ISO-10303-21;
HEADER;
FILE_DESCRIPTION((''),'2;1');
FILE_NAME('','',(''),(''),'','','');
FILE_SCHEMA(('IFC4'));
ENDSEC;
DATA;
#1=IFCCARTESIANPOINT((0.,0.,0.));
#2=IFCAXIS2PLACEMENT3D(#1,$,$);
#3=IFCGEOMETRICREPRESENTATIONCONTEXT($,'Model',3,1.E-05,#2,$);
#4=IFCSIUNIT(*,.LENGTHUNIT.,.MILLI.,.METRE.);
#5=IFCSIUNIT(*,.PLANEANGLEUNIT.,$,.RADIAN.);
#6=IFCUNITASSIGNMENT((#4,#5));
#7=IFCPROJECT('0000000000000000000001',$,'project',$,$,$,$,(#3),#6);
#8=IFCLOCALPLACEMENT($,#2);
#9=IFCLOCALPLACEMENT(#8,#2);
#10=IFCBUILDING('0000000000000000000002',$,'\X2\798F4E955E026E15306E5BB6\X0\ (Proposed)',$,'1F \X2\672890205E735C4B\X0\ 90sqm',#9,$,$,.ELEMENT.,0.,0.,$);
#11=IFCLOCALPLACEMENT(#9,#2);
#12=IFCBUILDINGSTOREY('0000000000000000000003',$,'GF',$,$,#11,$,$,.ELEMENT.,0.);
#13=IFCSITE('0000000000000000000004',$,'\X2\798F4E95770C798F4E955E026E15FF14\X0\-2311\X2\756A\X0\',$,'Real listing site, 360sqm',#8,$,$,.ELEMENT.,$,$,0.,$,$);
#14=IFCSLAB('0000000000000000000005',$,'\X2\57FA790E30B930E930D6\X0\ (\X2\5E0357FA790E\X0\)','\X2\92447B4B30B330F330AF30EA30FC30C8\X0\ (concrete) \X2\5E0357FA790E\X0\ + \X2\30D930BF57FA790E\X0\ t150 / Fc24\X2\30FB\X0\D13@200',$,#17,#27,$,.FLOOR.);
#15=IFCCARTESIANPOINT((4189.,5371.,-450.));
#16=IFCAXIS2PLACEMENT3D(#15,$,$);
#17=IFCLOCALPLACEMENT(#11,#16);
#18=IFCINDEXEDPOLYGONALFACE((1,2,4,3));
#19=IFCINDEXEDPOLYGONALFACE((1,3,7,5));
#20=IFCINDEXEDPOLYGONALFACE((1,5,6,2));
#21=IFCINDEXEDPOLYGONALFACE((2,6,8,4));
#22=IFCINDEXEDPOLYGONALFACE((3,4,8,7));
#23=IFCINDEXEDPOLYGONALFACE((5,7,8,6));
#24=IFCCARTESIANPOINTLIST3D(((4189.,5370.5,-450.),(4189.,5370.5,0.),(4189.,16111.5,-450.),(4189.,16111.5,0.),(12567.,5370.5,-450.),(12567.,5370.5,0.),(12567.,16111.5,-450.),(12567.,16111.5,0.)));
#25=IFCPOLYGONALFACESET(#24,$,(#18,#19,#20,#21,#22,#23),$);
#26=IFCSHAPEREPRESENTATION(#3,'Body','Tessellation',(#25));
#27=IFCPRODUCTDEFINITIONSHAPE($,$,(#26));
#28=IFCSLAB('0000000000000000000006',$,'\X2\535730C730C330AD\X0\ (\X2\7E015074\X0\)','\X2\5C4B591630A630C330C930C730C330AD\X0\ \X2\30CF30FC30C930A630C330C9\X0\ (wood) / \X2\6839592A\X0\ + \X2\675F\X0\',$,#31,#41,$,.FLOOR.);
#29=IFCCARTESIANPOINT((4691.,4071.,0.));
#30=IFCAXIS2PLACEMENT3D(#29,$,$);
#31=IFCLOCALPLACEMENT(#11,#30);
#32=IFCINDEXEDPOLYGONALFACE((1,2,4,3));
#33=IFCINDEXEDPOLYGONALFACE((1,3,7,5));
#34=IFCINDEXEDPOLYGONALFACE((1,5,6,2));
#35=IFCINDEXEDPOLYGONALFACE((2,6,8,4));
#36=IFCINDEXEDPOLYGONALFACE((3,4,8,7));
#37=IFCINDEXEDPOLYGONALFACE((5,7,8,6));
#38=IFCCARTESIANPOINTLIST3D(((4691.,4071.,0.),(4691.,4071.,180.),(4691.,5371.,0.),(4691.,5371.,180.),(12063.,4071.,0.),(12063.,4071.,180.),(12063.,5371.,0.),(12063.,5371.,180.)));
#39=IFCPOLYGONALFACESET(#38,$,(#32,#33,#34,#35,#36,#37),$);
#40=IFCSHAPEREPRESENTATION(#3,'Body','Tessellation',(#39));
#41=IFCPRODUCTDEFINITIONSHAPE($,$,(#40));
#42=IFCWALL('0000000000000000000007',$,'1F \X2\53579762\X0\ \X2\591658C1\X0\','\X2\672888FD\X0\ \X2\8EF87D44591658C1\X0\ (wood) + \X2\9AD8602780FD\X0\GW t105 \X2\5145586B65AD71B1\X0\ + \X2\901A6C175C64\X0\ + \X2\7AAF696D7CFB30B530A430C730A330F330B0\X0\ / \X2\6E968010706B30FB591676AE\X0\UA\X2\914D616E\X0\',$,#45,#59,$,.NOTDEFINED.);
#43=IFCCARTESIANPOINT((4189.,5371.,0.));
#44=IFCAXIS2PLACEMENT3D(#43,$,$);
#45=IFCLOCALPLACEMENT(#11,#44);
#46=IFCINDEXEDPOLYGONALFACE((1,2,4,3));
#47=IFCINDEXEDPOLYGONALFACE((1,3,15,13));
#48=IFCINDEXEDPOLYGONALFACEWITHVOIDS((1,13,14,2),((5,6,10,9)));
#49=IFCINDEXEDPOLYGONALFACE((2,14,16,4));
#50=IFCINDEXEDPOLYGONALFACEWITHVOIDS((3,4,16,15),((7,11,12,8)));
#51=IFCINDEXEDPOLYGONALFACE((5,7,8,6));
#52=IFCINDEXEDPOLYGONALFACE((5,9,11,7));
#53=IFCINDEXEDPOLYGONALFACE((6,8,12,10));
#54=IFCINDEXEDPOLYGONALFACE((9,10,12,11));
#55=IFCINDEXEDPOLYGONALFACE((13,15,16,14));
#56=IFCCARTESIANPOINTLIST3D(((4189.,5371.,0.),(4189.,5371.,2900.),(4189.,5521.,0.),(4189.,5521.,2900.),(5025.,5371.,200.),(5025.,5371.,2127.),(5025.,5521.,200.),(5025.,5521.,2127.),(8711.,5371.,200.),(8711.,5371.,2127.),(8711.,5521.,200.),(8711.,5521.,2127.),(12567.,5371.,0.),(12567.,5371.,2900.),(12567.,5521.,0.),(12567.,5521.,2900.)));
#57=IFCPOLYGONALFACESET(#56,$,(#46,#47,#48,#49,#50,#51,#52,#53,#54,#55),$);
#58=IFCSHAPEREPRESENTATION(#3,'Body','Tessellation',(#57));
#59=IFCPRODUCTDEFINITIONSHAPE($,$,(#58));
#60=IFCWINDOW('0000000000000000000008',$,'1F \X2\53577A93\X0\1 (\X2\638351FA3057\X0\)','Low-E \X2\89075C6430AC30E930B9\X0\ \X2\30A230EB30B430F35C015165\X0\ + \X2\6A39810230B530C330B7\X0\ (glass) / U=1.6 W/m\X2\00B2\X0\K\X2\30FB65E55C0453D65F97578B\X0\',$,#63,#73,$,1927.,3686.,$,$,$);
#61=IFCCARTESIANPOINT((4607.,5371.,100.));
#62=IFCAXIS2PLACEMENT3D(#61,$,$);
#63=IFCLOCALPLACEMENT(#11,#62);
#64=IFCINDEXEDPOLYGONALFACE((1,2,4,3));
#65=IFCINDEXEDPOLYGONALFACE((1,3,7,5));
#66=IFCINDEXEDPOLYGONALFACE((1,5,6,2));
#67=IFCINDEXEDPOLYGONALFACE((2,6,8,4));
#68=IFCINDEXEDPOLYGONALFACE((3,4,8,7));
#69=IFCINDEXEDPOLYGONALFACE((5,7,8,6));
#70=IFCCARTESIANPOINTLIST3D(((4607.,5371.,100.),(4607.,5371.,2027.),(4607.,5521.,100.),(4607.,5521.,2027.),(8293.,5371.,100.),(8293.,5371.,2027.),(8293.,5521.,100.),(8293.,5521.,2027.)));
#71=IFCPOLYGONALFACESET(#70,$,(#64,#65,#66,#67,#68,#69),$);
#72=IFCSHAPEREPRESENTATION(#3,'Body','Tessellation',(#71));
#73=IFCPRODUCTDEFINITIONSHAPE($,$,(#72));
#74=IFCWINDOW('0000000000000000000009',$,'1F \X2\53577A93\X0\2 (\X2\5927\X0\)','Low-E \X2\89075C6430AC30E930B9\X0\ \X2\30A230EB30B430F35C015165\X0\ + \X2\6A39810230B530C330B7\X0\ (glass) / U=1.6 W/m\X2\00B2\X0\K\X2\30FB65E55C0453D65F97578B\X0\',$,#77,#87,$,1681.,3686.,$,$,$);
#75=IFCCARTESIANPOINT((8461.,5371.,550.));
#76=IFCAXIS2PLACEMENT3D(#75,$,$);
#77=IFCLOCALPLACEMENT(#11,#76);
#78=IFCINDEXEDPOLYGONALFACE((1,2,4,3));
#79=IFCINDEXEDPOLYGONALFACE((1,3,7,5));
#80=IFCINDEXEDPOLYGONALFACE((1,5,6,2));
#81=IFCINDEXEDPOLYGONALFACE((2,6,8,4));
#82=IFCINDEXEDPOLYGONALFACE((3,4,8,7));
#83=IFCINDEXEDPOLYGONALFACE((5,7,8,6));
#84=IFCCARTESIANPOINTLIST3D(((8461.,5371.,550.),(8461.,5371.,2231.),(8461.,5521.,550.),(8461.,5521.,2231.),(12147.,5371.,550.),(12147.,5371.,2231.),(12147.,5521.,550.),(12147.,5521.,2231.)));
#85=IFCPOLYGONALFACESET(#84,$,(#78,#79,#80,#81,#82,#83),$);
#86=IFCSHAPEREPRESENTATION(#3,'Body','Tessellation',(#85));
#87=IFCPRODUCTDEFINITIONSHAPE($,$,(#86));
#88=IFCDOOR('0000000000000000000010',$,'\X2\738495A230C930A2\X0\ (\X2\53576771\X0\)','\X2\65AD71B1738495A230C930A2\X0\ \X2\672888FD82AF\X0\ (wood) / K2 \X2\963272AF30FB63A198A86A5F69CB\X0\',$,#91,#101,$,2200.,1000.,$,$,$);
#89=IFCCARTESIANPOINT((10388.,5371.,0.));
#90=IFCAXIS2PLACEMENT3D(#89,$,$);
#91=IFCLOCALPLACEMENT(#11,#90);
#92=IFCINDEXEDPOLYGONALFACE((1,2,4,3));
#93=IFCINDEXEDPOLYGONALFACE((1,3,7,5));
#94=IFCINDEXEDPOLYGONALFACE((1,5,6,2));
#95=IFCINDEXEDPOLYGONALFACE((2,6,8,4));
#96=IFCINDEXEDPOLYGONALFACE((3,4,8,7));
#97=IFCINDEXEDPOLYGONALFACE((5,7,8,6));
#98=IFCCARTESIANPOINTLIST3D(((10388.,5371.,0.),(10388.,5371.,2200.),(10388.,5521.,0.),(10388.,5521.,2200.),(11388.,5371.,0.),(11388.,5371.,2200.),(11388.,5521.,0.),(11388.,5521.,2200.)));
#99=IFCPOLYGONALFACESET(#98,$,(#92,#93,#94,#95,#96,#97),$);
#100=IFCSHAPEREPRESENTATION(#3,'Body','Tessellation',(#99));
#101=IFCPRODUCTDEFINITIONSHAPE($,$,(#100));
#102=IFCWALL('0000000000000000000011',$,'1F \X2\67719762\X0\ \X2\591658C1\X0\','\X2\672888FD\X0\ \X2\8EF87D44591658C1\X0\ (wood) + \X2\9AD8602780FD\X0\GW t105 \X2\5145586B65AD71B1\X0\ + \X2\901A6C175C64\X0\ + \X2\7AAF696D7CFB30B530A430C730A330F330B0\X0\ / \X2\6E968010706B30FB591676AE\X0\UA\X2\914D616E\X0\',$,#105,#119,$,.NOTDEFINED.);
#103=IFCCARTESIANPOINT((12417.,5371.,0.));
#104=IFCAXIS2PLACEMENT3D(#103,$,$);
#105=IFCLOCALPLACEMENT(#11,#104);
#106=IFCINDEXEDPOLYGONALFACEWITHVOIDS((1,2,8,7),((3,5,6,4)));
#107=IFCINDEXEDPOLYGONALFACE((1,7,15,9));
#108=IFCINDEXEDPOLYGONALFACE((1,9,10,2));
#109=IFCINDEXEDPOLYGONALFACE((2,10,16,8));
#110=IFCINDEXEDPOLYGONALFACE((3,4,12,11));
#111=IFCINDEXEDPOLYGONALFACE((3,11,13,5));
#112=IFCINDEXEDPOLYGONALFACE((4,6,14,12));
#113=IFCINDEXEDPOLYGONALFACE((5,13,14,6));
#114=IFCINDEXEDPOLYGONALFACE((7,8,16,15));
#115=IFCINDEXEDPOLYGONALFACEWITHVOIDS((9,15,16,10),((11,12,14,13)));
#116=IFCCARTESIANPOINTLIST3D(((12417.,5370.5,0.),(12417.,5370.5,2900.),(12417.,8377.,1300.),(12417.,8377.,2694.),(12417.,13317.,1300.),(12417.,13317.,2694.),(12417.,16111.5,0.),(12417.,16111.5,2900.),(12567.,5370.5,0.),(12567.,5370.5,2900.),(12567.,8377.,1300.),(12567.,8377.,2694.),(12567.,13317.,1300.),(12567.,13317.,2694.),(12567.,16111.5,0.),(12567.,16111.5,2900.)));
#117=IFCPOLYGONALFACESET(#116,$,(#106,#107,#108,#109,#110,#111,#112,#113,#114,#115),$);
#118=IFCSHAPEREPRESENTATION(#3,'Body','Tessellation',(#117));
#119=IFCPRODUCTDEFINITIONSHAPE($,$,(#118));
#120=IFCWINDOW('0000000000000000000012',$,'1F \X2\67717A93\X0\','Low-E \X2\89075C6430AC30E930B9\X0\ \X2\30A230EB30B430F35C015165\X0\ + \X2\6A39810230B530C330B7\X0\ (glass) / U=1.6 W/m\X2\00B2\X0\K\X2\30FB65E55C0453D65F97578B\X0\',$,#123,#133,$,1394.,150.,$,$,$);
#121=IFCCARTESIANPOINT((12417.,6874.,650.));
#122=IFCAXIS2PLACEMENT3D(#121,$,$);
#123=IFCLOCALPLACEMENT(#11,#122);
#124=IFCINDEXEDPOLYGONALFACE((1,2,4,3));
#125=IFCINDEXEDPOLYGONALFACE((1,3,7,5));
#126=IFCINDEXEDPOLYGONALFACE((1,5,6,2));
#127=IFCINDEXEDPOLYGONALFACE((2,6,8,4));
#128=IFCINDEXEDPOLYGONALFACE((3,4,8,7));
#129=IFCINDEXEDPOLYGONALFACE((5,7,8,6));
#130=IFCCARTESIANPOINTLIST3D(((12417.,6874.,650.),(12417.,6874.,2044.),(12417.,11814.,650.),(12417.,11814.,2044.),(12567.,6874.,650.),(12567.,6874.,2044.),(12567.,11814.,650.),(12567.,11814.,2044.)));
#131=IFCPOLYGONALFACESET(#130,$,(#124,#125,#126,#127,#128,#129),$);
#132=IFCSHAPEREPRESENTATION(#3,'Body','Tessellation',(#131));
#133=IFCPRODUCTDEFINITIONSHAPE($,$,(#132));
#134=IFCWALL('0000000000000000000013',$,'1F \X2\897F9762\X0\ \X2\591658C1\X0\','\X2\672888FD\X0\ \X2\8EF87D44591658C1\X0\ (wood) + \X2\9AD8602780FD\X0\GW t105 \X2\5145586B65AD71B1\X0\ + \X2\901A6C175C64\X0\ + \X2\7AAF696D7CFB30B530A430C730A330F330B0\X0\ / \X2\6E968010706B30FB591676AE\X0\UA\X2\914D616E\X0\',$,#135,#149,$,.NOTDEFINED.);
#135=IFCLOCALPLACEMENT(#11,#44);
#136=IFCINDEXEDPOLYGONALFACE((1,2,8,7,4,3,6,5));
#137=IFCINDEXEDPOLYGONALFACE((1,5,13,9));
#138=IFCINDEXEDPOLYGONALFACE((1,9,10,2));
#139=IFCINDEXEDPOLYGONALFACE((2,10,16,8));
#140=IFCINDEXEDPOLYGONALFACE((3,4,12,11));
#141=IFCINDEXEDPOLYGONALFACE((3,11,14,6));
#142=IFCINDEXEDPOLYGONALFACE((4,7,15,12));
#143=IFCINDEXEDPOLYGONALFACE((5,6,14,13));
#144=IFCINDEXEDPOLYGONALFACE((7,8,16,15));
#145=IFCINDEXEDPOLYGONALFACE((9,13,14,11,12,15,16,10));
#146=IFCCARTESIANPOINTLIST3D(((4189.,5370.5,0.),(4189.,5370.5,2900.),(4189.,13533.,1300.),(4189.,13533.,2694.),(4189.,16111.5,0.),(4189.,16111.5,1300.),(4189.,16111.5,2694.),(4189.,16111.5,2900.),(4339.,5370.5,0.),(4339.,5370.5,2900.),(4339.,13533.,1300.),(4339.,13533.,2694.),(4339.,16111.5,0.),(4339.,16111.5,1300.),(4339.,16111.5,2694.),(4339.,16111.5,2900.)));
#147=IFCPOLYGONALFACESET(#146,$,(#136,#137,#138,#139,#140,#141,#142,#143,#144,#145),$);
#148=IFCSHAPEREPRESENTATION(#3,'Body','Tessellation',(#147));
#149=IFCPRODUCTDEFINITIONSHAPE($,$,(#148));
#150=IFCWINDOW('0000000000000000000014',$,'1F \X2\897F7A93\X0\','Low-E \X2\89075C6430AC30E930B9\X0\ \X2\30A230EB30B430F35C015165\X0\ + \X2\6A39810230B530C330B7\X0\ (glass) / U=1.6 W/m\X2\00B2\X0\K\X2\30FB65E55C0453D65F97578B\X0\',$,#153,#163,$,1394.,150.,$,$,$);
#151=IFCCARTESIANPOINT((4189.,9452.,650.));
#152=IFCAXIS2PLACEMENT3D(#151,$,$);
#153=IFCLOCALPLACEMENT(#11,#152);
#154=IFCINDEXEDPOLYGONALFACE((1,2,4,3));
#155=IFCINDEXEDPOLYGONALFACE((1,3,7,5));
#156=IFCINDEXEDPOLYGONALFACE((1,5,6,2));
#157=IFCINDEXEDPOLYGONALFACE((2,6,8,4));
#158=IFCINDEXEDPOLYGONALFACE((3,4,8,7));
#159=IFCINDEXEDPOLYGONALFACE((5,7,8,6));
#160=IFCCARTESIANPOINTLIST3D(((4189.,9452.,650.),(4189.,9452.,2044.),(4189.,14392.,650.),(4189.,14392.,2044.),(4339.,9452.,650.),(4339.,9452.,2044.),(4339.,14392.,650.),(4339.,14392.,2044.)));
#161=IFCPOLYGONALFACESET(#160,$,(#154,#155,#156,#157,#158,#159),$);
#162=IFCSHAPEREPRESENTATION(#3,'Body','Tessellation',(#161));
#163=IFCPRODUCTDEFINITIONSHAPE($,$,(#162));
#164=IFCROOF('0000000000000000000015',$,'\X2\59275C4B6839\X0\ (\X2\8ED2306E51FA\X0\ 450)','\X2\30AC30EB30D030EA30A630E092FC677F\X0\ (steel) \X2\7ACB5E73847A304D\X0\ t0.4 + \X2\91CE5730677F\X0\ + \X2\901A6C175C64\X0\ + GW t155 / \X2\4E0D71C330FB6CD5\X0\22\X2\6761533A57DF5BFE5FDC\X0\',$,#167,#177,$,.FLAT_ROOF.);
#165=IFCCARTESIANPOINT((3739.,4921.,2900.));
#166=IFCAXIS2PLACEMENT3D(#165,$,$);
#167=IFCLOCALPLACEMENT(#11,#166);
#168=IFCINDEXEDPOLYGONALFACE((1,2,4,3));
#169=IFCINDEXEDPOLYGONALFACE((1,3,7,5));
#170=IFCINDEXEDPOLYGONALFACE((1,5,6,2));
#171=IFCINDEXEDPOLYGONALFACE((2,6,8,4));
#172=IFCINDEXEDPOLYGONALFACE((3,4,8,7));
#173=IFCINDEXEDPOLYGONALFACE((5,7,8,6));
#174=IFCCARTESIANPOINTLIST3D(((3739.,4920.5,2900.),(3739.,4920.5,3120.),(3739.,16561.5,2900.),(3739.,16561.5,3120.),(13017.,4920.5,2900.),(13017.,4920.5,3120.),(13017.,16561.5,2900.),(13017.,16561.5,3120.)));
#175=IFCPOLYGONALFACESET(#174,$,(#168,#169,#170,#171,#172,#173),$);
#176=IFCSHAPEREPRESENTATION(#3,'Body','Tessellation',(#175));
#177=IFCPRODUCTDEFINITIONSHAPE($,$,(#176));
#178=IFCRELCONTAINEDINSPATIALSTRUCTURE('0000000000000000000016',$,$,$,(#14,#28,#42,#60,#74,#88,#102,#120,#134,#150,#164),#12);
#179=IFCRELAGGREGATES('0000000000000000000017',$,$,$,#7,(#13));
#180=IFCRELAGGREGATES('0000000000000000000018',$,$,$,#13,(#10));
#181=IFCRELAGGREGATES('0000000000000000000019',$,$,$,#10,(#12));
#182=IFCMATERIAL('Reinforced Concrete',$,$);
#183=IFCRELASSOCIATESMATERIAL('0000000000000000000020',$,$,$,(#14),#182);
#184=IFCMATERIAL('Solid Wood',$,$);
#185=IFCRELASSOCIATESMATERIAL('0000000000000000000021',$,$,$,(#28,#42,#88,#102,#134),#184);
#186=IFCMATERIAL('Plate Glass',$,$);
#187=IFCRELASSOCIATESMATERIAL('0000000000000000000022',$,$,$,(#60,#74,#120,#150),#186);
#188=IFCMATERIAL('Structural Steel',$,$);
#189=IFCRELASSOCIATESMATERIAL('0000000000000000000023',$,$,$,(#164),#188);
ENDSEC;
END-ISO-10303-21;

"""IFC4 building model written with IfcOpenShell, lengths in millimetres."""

from ifc_helpers import new_model, si_unit, frame, frame_2d, origin, place, context, project, spatial, rectangle, extrude, material, element, fill, save


model = new_model("IFC4")

# Units and contexts
model_context = context("Model", 3, precision=1e-05, world=origin())
ifc_project = project(units=[si_unit("LENGTHUNIT", "METRE", prefix="MILLI"), si_unit("PLANEANGLEUNIT", "RADIAN")], contexts=[model_context])

# Site, building, storey
site_placement = place(None, origin())
site = spatial("IfcSite", under=ifc_project, at=site_placement, Name="福井県福井市渕４-2311番", ObjectType="Real listing site, 360sqm", CompositionType="ELEMENT", RefElevation=0.0)
building_placement = place(site_placement, origin())
building = spatial("IfcBuilding", under=site, at=building_placement, Name="福井市渕の家 (Proposed)", ObjectType="1F 木造平屋 90sqm", CompositionType="ELEMENT", ElevationOfRefHeight=0.0, ElevationOfTerrain=0.0)
storey_placement = place(building_placement, origin())
storey = spatial("IfcBuildingStorey", under=building, at=storey_placement, Name="GF", CompositionType="ELEMENT", Elevation=0.0)

# Slabs
ifc_material_1 = material(Name="Reinforced Concrete")
slab_1_placement = place(storey_placement, frame((4189.0, 5371.0, -450.0)))
element("IfcSlab", 1, at=slab_1_placement, inside=storey, material=ifc_material_1, Name="基礎スラブ (布基礎)", Description="鉄筋コンクリート (concrete) 布基礎 + ベタ基礎 t150 / Fc24・D13@200", PredefinedType="FLOOR", context=model_context, shape_type="SweptSolid", body=[
    extrude(rectangle(XDim=8378.0, YDim=10741.0, at=frame_2d((4189.0, 5370.0))), frame((4189.0, 5371.0, -450.0)), (0.0, 0.0, 1.0), 450.0),
])
ifc_material_2 = material(Name="Solid Wood")
slab_2_placement = place(storey_placement, frame((4691.0, 4071.0, 0.0)))
element("IfcSlab", 2, at=slab_2_placement, inside=storey, material=ifc_material_2, Name="南デッキ (縁側)", Description="屋外ウッドデッキ ハードウッド (wood) / 根太 + 束", PredefinedType="FLOOR", context=model_context, shape_type="SweptSolid", body=[
    extrude(rectangle(XDim=7372.0, YDim=1300.0, at=frame_2d((3686.0, 650.0))), frame((4691.0, 4071.0, 0.0)), (0.0, 0.0, 1.0), 180.0),
])

# Wall, openings, windows, door
wall_1_placement = place(storey_placement, frame((4189.0, 5371.0, 0.0)))
wall_1 = element("IfcWall", 3, at=wall_1_placement, inside=storey, material=ifc_material_2, Name="1F 南面 外壁", Description="木製 軸組外壁 (wood) + 高性能GW t105 充填断熱 + 通気層 + 窯業系サイディング / 準耐火・外皮UA配慮", PredefinedType="NOTDEFINED", context=model_context, shape_type="SweptSolid", body=[
    extrude(rectangle(XDim=8378.0, YDim=150.0, at=frame_2d((4189.0, 75.0))), frame((4189.0, 5371.0, 0.0)), (0.0, 0.0, 1.0), 2900.0),
])
opening_1_placement = place(storey_placement, frame((4607.0, 5371.0, 100.0)))
opening_1 = element("IfcOpeningElement", 4, at=opening_1_placement, cuts=wall_1, PredefinedType="NOTDEFINED", context=model_context, shape_type="SweptSolid", body=[
    extrude(rectangle(XDim=3686.0, YDim=150.0, at=frame_2d((1843.0, 75.0))), frame((4607.0, 5371.0, 100.0)), (0.0, 0.0, 1.0), 1927.0),
])
opening_2_placement = place(storey_placement, frame((8461.0, 5371.0, 550.0)))
opening_2 = element("IfcOpeningElement", 5, at=opening_2_placement, cuts=wall_1, PredefinedType="NOTDEFINED", context=model_context, shape_type="SweptSolid", body=[
    extrude(rectangle(XDim=3686.0, YDim=150.0, at=frame_2d((1843.0, 75.0))), frame((8461.0, 5371.0, 550.0)), (0.0, 0.0, 1.0), 1681.0),
])
opening_3_placement = place(storey_placement, frame((10388.0, 5371.0, 0.0)))
opening_3 = element("IfcOpeningElement", 6, at=opening_3_placement, cuts=wall_1, PredefinedType="NOTDEFINED", context=model_context, shape_type="SweptSolid", body=[
    extrude(rectangle(XDim=1000.0, YDim=150.0, at=frame_2d((500.0, 75.0))), frame((10388.0, 5371.0, 0.0)), (0.0, 0.0, 1.0), 2200.0),
])
ifc_material_3 = material(Name="Plate Glass")
window_1_placement = place(storey_placement, frame((4607.0, 5371.0, 100.0)))
window_1 = element("IfcWindow", 7, at=window_1_placement, inside=storey, material=ifc_material_3, Name="1F 南窓1 (掃出し)", Description="Low-E 複層ガラス アルゴン封入 + 樹脂サッシ (glass) / U=1.6 W/m²K・日射取得型", OverallHeight=1927.0, OverallWidth=3686.0, context=model_context, shape_type="SweptSolid", body=[
    extrude(rectangle(XDim=3686.0, YDim=150.0, at=frame_2d((1843.0, 75.0))), frame((4607.0, 5371.0, 100.0)), (0.0, 0.0, 1.0), 1927.0),
])
fill(opening_1, window_1)
window_2_placement = place(storey_placement, frame((8461.0, 5371.0, 550.0)))
window_2 = element("IfcWindow", 8, at=window_2_placement, inside=storey, material=ifc_material_3, Name="1F 南窓2 (大)", Description="Low-E 複層ガラス アルゴン封入 + 樹脂サッシ (glass) / U=1.6 W/m²K・日射取得型", OverallHeight=1681.0, OverallWidth=3686.0, context=model_context, shape_type="SweptSolid", body=[
    extrude(rectangle(XDim=3686.0, YDim=150.0, at=frame_2d((1843.0, 75.0))), frame((8461.0, 5371.0, 550.0)), (0.0, 0.0, 1.0), 1681.0),
])
fill(opening_2, window_2)
door_placement = place(storey_placement, frame((10388.0, 5371.0, 0.0)))
door = element("IfcDoor", 9, at=door_placement, inside=storey, material=ifc_material_2, Name="玄関ドア (南東)", Description="断熱玄関ドア 木製芯 (wood) / K2 防犯・採風機構", OverallHeight=2200.0, OverallWidth=1000.0, context=model_context, shape_type="SweptSolid", body=[
    extrude(rectangle(XDim=1000.0, YDim=150.0, at=frame_2d((500.0, 75.0))), frame((10388.0, 5371.0, 0.0)), (0.0, 0.0, 1.0), 2200.0),
])
fill(opening_3, door)

# Walls, openings, windows
wall_2_placement = place(storey_placement, frame((12417.0, 5371.0, 0.0)))
wall_2 = element("IfcWall", 10, at=wall_2_placement, inside=storey, material=ifc_material_2, Name="1F 東面 外壁", Description="木製 軸組外壁 (wood) + 高性能GW t105 充填断熱 + 通気層 + 窯業系サイディング / 準耐火・外皮UA配慮", PredefinedType="NOTDEFINED", context=model_context, shape_type="SweptSolid", body=[
    extrude(rectangle(XDim=150.0, YDim=10741.0, at=frame_2d((75.0, 5370.0))), frame((12417.0, 5371.0, 0.0)), (0.0, 0.0, 1.0), 2900.0),
])
opening_4_placement = place(storey_placement, frame((12417.0, 6874.0, 650.0)))
opening_4 = element("IfcOpeningElement", 11, at=opening_4_placement, cuts=wall_2, PredefinedType="NOTDEFINED", context=model_context, shape_type="SweptSolid", body=[
    extrude(rectangle(XDim=150.0, YDim=4940.0, at=frame_2d((75.0, 2470.0))), frame((12417.0, 6874.0, 650.0)), (0.0, 0.0, 1.0), 1394.0),
])
window_3_placement = place(storey_placement, frame((12417.0, 6874.0, 650.0)))
window_3 = element("IfcWindow", 12, at=window_3_placement, inside=storey, material=ifc_material_3, Name="1F 東窓", Description="Low-E 複層ガラス アルゴン封入 + 樹脂サッシ (glass) / U=1.6 W/m²K・日射取得型", OverallHeight=1394.0, OverallWidth=150.0, context=model_context, shape_type="SweptSolid", body=[
    extrude(rectangle(XDim=150.0, YDim=4940.0, at=frame_2d((75.0, 2470.0))), frame((12417.0, 6874.0, 650.0)), (0.0, 0.0, 1.0), 1394.0),
])
fill(opening_4, window_3)
wall_3_placement = place(storey_placement, frame((4189.0, 5371.0, 0.0)))
wall_3 = element("IfcWall", 13, at=wall_3_placement, inside=storey, material=ifc_material_2, Name="1F 西面 外壁", Description="木製 軸組外壁 (wood) + 高性能GW t105 充填断熱 + 通気層 + 窯業系サイディング / 準耐火・外皮UA配慮", PredefinedType="NOTDEFINED", context=model_context, shape_type="SweptSolid", body=[
    extrude(rectangle(XDim=150.0, YDim=10741.0, at=frame_2d((75.0, 5370.0))), frame((4189.0, 5371.0, 0.0)), (0.0, 0.0, 1.0), 2900.0),
])
opening_5_placement = place(storey_placement, frame((4189.0, 9452.0, 650.0)))
opening_5 = element("IfcOpeningElement", 14, at=opening_5_placement, cuts=wall_3, PredefinedType="NOTDEFINED", context=model_context, shape_type="SweptSolid", body=[
    extrude(rectangle(XDim=150.0, YDim=4940.0, at=frame_2d((75.0, 2470.0))), frame((4189.0, 9452.0, 650.0)), (0.0, 0.0, 1.0), 1394.0),
])
window_4_placement = place(storey_placement, frame((4189.0, 9452.0, 650.0)))
window_4 = element("IfcWindow", 15, at=window_4_placement, inside=storey, material=ifc_material_3, Name="1F 西窓", Description="Low-E 複層ガラス アルゴン封入 + 樹脂サッシ (glass) / U=1.6 W/m²K・日射取得型", OverallHeight=1394.0, OverallWidth=150.0, context=model_context, shape_type="SweptSolid", body=[
    extrude(rectangle(XDim=150.0, YDim=4940.0, at=frame_2d((75.0, 2470.0))), frame((4189.0, 9452.0, 650.0)), (0.0, 0.0, 1.0), 1394.0),
])
fill(opening_5, window_4)

# Roof
ifc_material_4 = material(Name="Structural Steel")
roof_placement = place(storey_placement, frame((3739.0, 4921.0, 2900.0)))
element("IfcRoof", 16, at=roof_placement, inside=storey, material=ifc_material_4, Name="大屋根 (軒の出 450)", Description="ガルバリウム鋼板 (steel) 立平葺き t0.4 + 野地板 + 通気層 + GW t155 / 不燃・法22条区域対応", PredefinedType="FLAT_ROOF", context=model_context, shape_type="SweptSolid", body=[
    extrude(rectangle(XDim=9278.0, YDim=11641.0, at=frame_2d((4639.0, 5820.0))), frame((3739.0, 4921.0, 2900.0)), (0.0, 0.0, 1.0), 220.0),
])

save(model, "model.ifc")
